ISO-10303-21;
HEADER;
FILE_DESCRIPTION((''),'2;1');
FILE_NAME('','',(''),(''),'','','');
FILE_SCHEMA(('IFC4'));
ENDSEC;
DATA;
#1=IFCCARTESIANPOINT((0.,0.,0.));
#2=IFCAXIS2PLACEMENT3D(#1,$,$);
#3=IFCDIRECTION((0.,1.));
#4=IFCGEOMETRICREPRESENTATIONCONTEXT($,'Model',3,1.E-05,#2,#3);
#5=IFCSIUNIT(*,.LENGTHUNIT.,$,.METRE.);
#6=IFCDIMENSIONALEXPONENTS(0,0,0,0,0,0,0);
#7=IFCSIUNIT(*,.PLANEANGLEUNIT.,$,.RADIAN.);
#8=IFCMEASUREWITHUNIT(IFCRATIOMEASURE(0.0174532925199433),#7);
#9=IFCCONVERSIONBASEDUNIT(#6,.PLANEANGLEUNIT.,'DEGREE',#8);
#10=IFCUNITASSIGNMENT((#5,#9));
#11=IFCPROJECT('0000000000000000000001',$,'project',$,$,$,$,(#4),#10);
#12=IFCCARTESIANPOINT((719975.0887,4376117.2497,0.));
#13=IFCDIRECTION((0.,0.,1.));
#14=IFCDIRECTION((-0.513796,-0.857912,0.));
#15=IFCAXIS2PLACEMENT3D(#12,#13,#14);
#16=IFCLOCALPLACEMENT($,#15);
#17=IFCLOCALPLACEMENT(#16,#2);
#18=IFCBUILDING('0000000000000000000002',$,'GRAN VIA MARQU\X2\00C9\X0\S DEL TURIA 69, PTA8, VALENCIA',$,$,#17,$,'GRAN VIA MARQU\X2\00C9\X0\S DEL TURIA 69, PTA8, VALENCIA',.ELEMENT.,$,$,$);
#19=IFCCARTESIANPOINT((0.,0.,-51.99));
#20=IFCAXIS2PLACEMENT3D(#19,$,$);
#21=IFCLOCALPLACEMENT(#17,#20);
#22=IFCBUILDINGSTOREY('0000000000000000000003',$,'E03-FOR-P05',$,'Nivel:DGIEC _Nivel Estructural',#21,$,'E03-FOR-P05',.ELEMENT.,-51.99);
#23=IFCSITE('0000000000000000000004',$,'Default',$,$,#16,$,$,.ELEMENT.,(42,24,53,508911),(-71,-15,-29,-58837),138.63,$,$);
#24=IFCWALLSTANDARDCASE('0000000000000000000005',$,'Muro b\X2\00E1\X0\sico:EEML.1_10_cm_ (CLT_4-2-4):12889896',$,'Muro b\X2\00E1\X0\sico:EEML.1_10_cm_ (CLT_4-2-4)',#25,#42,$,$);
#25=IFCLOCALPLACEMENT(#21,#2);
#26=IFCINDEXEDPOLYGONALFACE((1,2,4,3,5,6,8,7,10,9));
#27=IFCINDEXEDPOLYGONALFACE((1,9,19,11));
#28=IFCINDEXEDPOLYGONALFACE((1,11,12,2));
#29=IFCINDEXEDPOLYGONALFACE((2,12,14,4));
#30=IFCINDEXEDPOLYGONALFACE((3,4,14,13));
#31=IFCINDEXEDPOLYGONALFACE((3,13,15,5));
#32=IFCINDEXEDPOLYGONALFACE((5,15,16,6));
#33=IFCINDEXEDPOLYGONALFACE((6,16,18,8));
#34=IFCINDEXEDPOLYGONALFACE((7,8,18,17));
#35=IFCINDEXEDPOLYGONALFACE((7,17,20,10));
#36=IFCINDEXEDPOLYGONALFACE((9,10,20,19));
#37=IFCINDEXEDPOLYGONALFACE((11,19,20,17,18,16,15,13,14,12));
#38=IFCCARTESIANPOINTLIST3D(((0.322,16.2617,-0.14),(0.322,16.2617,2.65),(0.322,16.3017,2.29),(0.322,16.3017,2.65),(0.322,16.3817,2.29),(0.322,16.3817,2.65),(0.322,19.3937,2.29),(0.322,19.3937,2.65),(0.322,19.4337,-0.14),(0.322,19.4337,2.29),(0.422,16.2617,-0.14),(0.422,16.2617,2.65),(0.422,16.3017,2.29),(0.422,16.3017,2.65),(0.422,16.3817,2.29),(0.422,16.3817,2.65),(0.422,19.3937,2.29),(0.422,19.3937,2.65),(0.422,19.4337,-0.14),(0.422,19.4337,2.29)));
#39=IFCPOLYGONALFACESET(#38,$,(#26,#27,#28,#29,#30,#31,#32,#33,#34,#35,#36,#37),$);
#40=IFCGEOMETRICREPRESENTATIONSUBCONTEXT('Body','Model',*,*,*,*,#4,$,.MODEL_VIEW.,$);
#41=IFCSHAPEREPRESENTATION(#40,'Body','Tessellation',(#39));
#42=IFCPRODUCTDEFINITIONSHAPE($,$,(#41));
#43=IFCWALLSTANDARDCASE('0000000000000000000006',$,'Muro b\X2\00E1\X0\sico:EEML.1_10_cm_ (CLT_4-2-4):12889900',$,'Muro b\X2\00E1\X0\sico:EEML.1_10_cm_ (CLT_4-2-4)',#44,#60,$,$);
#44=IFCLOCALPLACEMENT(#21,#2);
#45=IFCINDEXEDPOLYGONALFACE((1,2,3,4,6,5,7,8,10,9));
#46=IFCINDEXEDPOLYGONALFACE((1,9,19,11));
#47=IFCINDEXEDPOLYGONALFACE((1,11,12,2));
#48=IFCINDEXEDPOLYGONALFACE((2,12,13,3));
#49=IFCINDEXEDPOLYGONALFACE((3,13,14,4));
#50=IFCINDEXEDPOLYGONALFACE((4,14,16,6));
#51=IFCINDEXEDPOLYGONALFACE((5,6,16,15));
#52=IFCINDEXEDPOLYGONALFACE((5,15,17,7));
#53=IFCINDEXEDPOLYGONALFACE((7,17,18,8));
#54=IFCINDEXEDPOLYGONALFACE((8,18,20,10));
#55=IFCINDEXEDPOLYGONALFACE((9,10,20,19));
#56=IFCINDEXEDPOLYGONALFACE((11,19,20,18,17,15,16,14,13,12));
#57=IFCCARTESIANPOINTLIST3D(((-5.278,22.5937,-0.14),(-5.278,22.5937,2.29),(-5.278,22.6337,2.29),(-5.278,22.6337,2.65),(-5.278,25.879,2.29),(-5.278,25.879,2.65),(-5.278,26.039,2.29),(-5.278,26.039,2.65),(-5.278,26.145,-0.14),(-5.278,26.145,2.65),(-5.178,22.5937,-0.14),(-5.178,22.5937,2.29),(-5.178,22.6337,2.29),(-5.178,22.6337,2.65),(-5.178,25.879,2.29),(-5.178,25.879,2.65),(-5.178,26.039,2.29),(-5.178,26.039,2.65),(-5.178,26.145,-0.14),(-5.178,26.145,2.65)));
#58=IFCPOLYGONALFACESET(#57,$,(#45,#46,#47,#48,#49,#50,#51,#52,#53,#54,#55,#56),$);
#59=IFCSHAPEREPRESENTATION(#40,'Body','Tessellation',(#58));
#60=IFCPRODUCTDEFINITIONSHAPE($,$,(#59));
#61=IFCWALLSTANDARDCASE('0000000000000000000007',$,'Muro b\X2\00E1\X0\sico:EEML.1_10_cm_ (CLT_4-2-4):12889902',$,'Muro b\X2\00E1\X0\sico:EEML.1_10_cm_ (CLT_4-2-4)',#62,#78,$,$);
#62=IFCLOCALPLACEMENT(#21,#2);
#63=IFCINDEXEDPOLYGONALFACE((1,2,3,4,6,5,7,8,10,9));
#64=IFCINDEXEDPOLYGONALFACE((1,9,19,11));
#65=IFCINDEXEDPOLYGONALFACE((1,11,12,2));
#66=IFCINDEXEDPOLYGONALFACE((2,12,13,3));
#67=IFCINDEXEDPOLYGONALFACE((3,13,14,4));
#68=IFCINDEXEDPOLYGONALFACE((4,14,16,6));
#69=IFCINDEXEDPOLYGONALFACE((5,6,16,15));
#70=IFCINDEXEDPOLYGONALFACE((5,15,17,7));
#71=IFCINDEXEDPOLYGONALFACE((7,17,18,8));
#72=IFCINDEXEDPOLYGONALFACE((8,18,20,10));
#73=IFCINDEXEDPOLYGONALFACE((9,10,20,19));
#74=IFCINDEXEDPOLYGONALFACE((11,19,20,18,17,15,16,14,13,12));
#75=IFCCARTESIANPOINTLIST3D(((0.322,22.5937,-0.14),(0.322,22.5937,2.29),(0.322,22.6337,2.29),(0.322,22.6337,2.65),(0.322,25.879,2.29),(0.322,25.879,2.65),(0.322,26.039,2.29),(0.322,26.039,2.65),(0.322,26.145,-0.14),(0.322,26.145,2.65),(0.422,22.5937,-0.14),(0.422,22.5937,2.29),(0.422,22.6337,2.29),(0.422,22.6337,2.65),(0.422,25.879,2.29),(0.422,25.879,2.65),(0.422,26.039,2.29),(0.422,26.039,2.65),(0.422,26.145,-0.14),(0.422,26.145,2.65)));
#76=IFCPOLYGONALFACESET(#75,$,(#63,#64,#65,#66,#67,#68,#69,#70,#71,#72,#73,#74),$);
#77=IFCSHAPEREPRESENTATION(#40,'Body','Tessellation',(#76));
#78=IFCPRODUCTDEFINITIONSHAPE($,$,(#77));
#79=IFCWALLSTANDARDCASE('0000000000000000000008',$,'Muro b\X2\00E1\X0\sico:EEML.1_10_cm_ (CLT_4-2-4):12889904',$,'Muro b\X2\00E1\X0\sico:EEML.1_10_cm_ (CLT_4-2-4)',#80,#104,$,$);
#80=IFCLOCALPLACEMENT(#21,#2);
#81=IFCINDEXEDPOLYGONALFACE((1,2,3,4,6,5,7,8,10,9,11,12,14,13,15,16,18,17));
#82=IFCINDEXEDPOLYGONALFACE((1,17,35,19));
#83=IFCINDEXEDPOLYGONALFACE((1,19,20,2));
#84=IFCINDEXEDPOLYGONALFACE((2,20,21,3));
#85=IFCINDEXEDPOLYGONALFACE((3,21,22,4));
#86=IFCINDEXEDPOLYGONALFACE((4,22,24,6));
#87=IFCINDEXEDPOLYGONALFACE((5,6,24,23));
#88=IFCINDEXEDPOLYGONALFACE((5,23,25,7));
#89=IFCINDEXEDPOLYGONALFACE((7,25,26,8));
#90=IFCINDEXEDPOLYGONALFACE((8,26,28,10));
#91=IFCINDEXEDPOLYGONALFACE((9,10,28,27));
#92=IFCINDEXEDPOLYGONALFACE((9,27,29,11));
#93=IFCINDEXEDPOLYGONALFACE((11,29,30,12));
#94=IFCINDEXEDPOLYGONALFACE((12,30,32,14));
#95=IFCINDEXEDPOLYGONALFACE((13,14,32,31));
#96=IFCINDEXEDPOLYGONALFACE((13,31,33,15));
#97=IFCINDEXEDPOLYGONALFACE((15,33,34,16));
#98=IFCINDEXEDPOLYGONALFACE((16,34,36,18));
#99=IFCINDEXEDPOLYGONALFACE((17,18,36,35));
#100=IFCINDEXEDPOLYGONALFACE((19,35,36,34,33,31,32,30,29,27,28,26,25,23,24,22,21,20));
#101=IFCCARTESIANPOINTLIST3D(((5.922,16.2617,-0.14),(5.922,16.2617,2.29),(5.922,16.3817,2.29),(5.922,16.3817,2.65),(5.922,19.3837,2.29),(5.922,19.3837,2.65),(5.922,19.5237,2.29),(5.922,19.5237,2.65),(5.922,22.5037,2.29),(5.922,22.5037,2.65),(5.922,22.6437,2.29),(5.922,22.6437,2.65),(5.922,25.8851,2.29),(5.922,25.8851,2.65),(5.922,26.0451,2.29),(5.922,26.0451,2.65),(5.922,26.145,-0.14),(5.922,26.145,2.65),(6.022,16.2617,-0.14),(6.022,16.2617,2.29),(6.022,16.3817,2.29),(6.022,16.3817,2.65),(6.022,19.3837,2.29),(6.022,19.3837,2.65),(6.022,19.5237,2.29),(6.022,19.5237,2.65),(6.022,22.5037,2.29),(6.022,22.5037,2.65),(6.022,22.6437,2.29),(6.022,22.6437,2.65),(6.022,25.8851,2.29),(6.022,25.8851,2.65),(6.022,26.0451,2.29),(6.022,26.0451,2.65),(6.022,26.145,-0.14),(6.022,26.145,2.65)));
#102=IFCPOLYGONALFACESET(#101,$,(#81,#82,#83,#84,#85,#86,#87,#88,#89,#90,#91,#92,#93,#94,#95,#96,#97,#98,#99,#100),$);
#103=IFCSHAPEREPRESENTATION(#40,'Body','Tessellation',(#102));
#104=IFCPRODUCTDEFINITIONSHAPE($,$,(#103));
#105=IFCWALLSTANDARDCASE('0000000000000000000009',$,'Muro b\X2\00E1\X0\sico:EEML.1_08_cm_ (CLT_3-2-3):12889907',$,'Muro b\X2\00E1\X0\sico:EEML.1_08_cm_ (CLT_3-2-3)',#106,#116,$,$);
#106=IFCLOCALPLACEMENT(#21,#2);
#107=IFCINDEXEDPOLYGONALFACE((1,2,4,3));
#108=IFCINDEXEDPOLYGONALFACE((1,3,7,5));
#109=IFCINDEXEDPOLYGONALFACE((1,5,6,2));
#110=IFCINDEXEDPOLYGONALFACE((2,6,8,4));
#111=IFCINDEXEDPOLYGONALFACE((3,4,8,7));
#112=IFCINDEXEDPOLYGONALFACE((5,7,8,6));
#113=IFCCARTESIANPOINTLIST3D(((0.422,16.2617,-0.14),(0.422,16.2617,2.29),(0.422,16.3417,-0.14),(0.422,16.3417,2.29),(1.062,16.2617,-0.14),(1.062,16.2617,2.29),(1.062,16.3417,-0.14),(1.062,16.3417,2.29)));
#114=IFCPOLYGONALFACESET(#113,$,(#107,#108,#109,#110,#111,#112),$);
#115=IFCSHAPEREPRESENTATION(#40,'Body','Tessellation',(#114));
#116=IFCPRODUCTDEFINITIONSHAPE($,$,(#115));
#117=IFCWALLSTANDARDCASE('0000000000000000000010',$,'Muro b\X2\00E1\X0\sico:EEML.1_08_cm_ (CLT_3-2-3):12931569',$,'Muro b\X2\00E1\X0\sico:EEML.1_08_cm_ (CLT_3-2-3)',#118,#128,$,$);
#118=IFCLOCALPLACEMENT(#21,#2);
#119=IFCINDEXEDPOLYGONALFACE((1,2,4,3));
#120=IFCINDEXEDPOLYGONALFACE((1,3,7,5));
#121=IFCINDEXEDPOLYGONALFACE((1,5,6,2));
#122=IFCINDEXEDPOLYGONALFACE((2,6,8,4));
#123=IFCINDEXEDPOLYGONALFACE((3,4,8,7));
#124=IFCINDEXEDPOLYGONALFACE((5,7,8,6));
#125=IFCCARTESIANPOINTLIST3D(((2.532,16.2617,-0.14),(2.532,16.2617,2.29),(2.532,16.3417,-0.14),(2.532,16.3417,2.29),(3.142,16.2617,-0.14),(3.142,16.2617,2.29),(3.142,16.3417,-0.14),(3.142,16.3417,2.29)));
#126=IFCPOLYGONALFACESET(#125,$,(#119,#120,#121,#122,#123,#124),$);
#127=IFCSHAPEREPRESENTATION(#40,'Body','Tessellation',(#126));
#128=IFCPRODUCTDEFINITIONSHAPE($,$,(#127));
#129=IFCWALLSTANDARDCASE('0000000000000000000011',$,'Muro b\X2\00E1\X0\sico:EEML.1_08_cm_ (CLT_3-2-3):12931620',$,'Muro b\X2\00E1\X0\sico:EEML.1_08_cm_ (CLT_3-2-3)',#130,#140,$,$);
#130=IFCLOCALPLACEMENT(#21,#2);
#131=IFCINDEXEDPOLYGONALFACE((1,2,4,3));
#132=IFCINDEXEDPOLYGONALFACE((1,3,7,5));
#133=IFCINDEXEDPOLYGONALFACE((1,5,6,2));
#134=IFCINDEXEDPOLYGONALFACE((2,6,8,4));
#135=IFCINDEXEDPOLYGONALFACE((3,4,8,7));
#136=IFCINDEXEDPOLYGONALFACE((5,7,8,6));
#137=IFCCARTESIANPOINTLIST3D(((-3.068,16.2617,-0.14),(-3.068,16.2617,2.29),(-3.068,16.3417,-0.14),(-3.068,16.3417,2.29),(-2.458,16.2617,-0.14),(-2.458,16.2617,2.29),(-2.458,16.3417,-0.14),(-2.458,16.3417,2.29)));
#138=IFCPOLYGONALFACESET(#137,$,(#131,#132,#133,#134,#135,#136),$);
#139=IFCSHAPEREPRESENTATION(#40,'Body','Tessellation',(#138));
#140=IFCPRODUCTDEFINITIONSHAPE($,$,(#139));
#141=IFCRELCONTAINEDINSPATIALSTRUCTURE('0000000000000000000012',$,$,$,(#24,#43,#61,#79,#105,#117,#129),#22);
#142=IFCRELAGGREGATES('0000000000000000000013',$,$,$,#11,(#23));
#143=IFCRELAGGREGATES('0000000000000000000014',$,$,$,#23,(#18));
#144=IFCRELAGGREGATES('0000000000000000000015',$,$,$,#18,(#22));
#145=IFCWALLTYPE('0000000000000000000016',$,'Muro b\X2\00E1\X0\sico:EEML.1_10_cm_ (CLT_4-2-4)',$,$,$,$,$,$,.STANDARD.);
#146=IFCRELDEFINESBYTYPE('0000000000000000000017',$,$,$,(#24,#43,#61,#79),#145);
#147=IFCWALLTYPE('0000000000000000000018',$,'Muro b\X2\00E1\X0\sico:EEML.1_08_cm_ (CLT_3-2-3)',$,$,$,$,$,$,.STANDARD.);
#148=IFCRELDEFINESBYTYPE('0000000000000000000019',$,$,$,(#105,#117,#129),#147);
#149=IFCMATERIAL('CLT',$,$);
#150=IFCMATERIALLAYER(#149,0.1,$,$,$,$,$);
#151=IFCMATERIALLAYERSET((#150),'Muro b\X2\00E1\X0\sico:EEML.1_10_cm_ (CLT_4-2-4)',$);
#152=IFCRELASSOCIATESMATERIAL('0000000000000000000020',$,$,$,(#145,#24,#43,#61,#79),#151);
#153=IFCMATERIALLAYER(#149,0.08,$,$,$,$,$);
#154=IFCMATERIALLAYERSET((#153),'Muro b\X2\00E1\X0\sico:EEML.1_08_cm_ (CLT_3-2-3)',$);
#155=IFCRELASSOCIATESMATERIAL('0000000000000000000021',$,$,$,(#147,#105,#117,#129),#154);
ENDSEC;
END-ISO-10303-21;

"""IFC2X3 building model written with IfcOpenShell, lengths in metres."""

from ifc_helpers import new_model, entity, si_unit, converted_unit, direction, frame, frame_2d, origin, place, context, subcontext, project, spatial, rectangle, extrude, material, layer, layer_set, layer_usage, type_object, element, save


model = new_model("IFC2X3")

# Units and contexts
model_context = context("Model", 3, precision=1e-05, world=origin(), true_north=direction((0.0, 1.0)))
body_context = subcontext(model_context, "Body", "Model", "MODEL_VIEW")
ifc_project = project(units=[si_unit("LENGTHUNIT", "METRE"), converted_unit("PLANEANGLEUNIT", "DEGREE", entity("IfcRatioMeasure", 0.0174532925199433), si_unit("PLANEANGLEUNIT", "RADIAN"), dimensions=[0, 0, 0, 0, 0, 0, 0])], contexts=[model_context])

# Site, building, storey
site_placement = place(None, frame((719975.0887, 4376117.2497, 0.0), z_axis=(0.0, 0.0, 1.0), x_axis=(-0.513796, -0.857912, 0.0)))
site = spatial("IfcSite", under=ifc_project, at=site_placement, Name="Default", CompositionType="ELEMENT", RefLatitude=(42, 24, 53, 508911), RefLongitude=(-71, -15, -29, -58837), RefElevation=138.63)
building_placement = place(site_placement, origin())
building = spatial("IfcBuilding", under=site, at=building_placement, Name="GRAN VIA MARQUÉS DEL TURIA 69, PTA8, VALENCIA", LongName="GRAN VIA MARQUÉS DEL TURIA 69, PTA8, VALENCIA", CompositionType="ELEMENT")
storey_placement = place(building_placement, frame((0.0, 0.0, -51.99)))
storey = spatial("IfcBuildingStorey", under=building, at=storey_placement, Name="E03-FOR-P05", ObjectType="Nivel:DGIEC _Nivel Estructural", LongName="E03-FOR-P05", CompositionType="ELEMENT", Elevation=-51.99)

# Shared definitions
ifc_material = material(Name="CLT")

# Walls, openings
ifc_layer_1 = layer(ifc_material, 0.1)
ifc_layer_set_1 = layer_set([ifc_layer_1], Name="Muro básico:EEML.1_10_cm_ (CLT_4-2-4)")
ifc_layer_usage_1 = layer_usage(ifc_layer_set_1, "AXIS2", "NEGATIVE", 0.05)
wall_type_1 = type_object("IfcWallType", Name="Muro básico:EEML.1_10_cm_ (CLT_4-2-4)", PredefinedType="STANDARD", material=ifc_layer_set_1)
wall_1_placement = place(storey_placement, frame((0.372, 16.2617, -0.14), z_axis=(0.0, 0.0, 1.0), x_axis=(0.0, 1.0, 0.0)))
wall_1 = element("IfcWallStandardCase", 1, at=wall_1_placement, inside=storey, type_object=wall_type_1, material=ifc_layer_usage_1, Name="Muro básico:EEML.1_10_cm_ (CLT_4-2-4):12889896", ObjectType="Muro básico:EEML.1_10_cm_ (CLT_4-2-4)", context=body_context, shape_type="SweptSolid", body=[
    extrude(rectangle(XDim=3.172, YDim=0.1, at=frame_2d((1.586, 0.0), x_axis=(-1.0, 0.0))), origin(), (0.0, 0.0, 1.0), 2.79),
])
opening_1_placement = place(wall_1_placement, origin())
element("IfcOpeningElement", 2, at=opening_1_placement, cuts=wall_1, ObjectType="Opening", context=body_context, shape_type="SweptSolid", body=[
    extrude(rectangle(XDim=0.36, YDim=0.08, at=frame_2d((0.0, 0.0), x_axis=(1.0, 0.0))), frame((3.172, 0.05, 2.61), z_axis=(0.0, -1.0, 0.0), x_axis=(0.0, 0.0, 1.0)), (0.0, 0.0, 1.0), 0.1),
])
opening_2_placement = place(wall_1_placement, origin())
element("IfcOpeningElement", 3, at=opening_2_placement, cuts=wall_1, ObjectType="Opening", context=body_context, shape_type="SweptSolid", body=[
    extrude(rectangle(XDim=0.36, YDim=0.08, at=frame_2d((0.0, 0.0), x_axis=(0.0, 1.0))), frame((0.08, 0.05, 2.61), z_axis=(0.0, -1.0, 0.0), x_axis=(-1.0, 0.0, 0.0)), (0.0, 0.0, 1.0), 0.1),
])
ifc_layer_usage_2 = layer_usage(ifc_layer_set_1, "AXIS2", "NEGATIVE", 0.05)
wall_2_placement = place(storey_placement, frame((-5.228, 22.5937, -0.14), z_axis=(0.0, 0.0, 1.0), x_axis=(0.0, 1.0, 0.0)))
wall_2 = element("IfcWallStandardCase", 4, at=wall_2_placement, inside=storey, type_object=wall_type_1, material=ifc_layer_usage_2, Name="Muro básico:EEML.1_10_cm_ (CLT_4-2-4):12889900", ObjectType="Muro básico:EEML.1_10_cm_ (CLT_4-2-4)", context=body_context, shape_type="SweptSolid", body=[
    extrude(rectangle(XDim=3.5513, YDim=0.1, at=frame_2d((1.7757, 0.0), x_axis=(-1.0, 0.0))), origin(), (0.0, 0.0, 1.0), 2.79),
])
opening_3_placement = place(wall_2_placement, origin())
element("IfcOpeningElement", 5, at=opening_3_placement, cuts=wall_2, ObjectType="Opening", context=body_context, shape_type="SweptSolid", body=[
    extrude(rectangle(XDim=0.36, YDim=0.16, at=frame_2d((0.0, 0.0), x_axis=(0.0, 1.0))), frame((3.3653, 0.05, 2.61), z_axis=(0.0, -1.0, 0.0), x_axis=(-1.0, 0.0, 0.0)), (0.0, 0.0, 1.0), 0.1),
])
opening_4_placement = place(wall_2_placement, origin())
element("IfcOpeningElement", 6, at=opening_4_placement, cuts=wall_2, ObjectType="Opening", context=body_context, shape_type="SweptSolid", body=[
    extrude(rectangle(XDim=0.36, YDim=0.08, at=frame_2d((0.0, 0.0), x_axis=(0.0, 1.0))), frame((0.0, 0.05, 2.61), z_axis=(0.0, -1.0, 0.0), x_axis=(-1.0, 0.0, 0.0)), (0.0, 0.0, 1.0), 0.1),
])
ifc_layer_usage_3 = layer_usage(ifc_layer_set_1, "AXIS2", "NEGATIVE", 0.05)
wall_3_placement = place(storey_placement, frame((0.372, 22.5937, -0.14), z_axis=(0.0, 0.0, 1.0), x_axis=(0.0, 1.0, 0.0)))
wall_3 = element("IfcWallStandardCase", 7, at=wall_3_placement, inside=storey, type_object=wall_type_1, material=ifc_layer_usage_3, Name="Muro básico:EEML.1_10_cm_ (CLT_4-2-4):12889902", ObjectType="Muro básico:EEML.1_10_cm_ (CLT_4-2-4)", context=body_context, shape_type="SweptSolid", body=[
    extrude(rectangle(XDim=3.5513, YDim=0.1, at=frame_2d((1.7757, 0.0), x_axis=(-1.0, 0.0))), origin(), (0.0, 0.0, 1.0), 2.79),
])
opening_5_placement = place(wall_3_placement, origin())
element("IfcOpeningElement", 8, at=opening_5_placement, cuts=wall_3, ObjectType="Opening", context=body_context, shape_type="SweptSolid", body=[
    extrude(rectangle(XDim=0.36, YDim=0.16, at=frame_2d((0.0, 0.0), x_axis=(0.0, 1.0))), frame((3.3653, 0.05, 2.61), z_axis=(0.0, -1.0, 0.0), x_axis=(-1.0, 0.0, 0.0)), (0.0, 0.0, 1.0), 0.1),
])
opening_6_placement = place(wall_3_placement, origin())
element("IfcOpeningElement", 9, at=opening_6_placement, cuts=wall_3, ObjectType="Opening", context=body_context, shape_type="SweptSolid", body=[
    extrude(rectangle(XDim=0.36, YDim=0.08, at=frame_2d((0.0, 0.0), x_axis=(0.0, 1.0))), frame((0.0, 0.05, 2.61), z_axis=(0.0, -1.0, 0.0), x_axis=(-1.0, 0.0, 0.0)), (0.0, 0.0, 1.0), 0.1),
])
ifc_layer_usage_4 = layer_usage(ifc_layer_set_1, "AXIS2", "NEGATIVE", 0.05)
wall_4_placement = place(storey_placement, frame((5.972, 16.2617, -0.14), z_axis=(0.0, 0.0, 1.0), x_axis=(0.0, 1.0, 0.0)))
wall_4 = element("IfcWallStandardCase", 10, at=wall_4_placement, inside=storey, type_object=wall_type_1, material=ifc_layer_usage_4, Name="Muro básico:EEML.1_10_cm_ (CLT_4-2-4):12889904", ObjectType="Muro básico:EEML.1_10_cm_ (CLT_4-2-4)", context=body_context, shape_type="SweptSolid", body=[
    extrude(rectangle(XDim=9.8833, YDim=0.1, at=frame_2d((4.9417, 0.0), x_axis=(-1.0, 0.0))), origin(), (0.0, 0.0, 1.0), 2.79),
])
opening_7_placement = place(wall_4_placement, origin())
element("IfcOpeningElement", 11, at=opening_7_placement, cuts=wall_4, ObjectType="Opening", context=body_context, shape_type="SweptSolid", body=[
    extrude(rectangle(XDim=0.36, YDim=0.16, at=frame_2d((0.0, 0.0), x_axis=(0.0, 1.0))), frame((9.7034, 0.05, 2.61), z_axis=(0.0, -1.0, 0.0), x_axis=(-1.0, 0.0, 0.0)), (0.0, 0.0, 1.0), 0.1),
])
opening_8_placement = place(wall_4_placement, origin())
element("IfcOpeningElement", 12, at=opening_8_placement, cuts=wall_4, ObjectType="Opening", context=body_context, shape_type="SweptSolid", body=[
    extrude(rectangle(XDim=0.36, YDim=0.14, at=frame_2d((0.0, 0.0), x_axis=(0.0, 1.0))), frame((6.312, 0.05, 2.61), z_axis=(0.0, -1.0, 0.0), x_axis=(-1.0, 0.0, 0.0)), (0.0, 0.0, 1.0), 0.1),
])
opening_9_placement = place(wall_4_placement, origin())
element("IfcOpeningElement", 13, at=opening_9_placement, cuts=wall_4, ObjectType="Opening", context=body_context, shape_type="SweptSolid", body=[
    extrude(rectangle(XDim=0.36, YDim=0.14, at=frame_2d((0.0, 0.0), x_axis=(0.0, 1.0))), frame((3.192, 0.05, 2.61), z_axis=(0.0, -1.0, 0.0), x_axis=(-1.0, 0.0, 0.0)), (0.0, 0.0, 1.0), 0.1),
])
opening_10_placement = place(wall_4_placement, origin())
element("IfcOpeningElement", 14, at=opening_10_placement, cuts=wall_4, ObjectType="Opening", context=body_context, shape_type="SweptSolid", body=[
    extrude(rectangle(XDim=0.36, YDim=0.12, at=frame_2d((0.0, 0.0), x_axis=(0.0, 1.0))), frame((0.06, 0.05, 2.61), z_axis=(0.0, -1.0, 0.0), x_axis=(-1.0, 0.0, 0.0)), (0.0, 0.0, 1.0), 0.1),
])

# Walls
ifc_layer_2 = layer(ifc_material, 0.08)
ifc_layer_set_2 = layer_set([ifc_layer_2], Name="Muro básico:EEML.1_08_cm_ (CLT_3-2-3)")
ifc_layer_usage_5 = layer_usage(ifc_layer_set_2, "AXIS2", "NEGATIVE", 0.04)
wall_type_2 = type_object("IfcWallType", Name="Muro básico:EEML.1_08_cm_ (CLT_3-2-3)", PredefinedType="STANDARD", material=ifc_layer_set_2)
wall_5_placement = place(storey_placement, frame((1.062, 16.3017, -0.14), z_axis=(0.0, 0.0, 1.0), x_axis=(-1.0, 0.0, 0.0)))
element("IfcWallStandardCase", 15, at=wall_5_placement, inside=storey, type_object=wall_type_2, material=ifc_layer_usage_5, Name="Muro básico:EEML.1_08_cm_ (CLT_3-2-3):12889907", ObjectType="Muro básico:EEML.1_08_cm_ (CLT_3-2-3)", context=body_context, shape_type="SweptSolid", body=[
    extrude(rectangle(XDim=0.64, YDim=0.08, at=frame_2d((0.32, 0.0), x_axis=(-1.0, 0.0))), origin(), (0.0, 0.0, 1.0), 2.43),
])
ifc_layer_usage_6 = layer_usage(ifc_layer_set_2, "AXIS2", "NEGATIVE", 0.04)
wall_6_placement = place(storey_placement, frame((3.142, 16.3017, -0.14), z_axis=(0.0, 0.0, 1.0), x_axis=(-1.0, 0.0, 0.0)))
element("IfcWallStandardCase", 16, at=wall_6_placement, inside=storey, type_object=wall_type_2, material=ifc_layer_usage_6, Name="Muro básico:EEML.1_08_cm_ (CLT_3-2-3):12931569", ObjectType="Muro básico:EEML.1_08_cm_ (CLT_3-2-3)", context=body_context, shape_type="SweptSolid", body=[
    extrude(rectangle(XDim=0.61, YDim=0.08, at=frame_2d((0.305, 0.0), x_axis=(-1.0, 0.0))), origin(), (0.0, 0.0, 1.0), 2.43),
])
ifc_layer_usage_7 = layer_usage(ifc_layer_set_2, "AXIS2", "NEGATIVE", 0.04)
wall_7_placement = place(storey_placement, frame((-2.458, 16.3017, -0.14), z_axis=(0.0, 0.0, 1.0), x_axis=(-1.0, 0.0, 0.0)))
element("IfcWallStandardCase", 17, at=wall_7_placement, inside=storey, type_object=wall_type_2, material=ifc_layer_usage_7, Name="Muro básico:EEML.1_08_cm_ (CLT_3-2-3):12931620", ObjectType="Muro básico:EEML.1_08_cm_ (CLT_3-2-3)", context=body_context, shape_type="SweptSolid", body=[
    extrude(rectangle(XDim=0.61, YDim=0.08, at=frame_2d((0.305, 0.0), x_axis=(-1.0, 0.0))), origin(), (0.0, 0.0, 1.0), 2.43),
])

save(model, "model.ifc")
